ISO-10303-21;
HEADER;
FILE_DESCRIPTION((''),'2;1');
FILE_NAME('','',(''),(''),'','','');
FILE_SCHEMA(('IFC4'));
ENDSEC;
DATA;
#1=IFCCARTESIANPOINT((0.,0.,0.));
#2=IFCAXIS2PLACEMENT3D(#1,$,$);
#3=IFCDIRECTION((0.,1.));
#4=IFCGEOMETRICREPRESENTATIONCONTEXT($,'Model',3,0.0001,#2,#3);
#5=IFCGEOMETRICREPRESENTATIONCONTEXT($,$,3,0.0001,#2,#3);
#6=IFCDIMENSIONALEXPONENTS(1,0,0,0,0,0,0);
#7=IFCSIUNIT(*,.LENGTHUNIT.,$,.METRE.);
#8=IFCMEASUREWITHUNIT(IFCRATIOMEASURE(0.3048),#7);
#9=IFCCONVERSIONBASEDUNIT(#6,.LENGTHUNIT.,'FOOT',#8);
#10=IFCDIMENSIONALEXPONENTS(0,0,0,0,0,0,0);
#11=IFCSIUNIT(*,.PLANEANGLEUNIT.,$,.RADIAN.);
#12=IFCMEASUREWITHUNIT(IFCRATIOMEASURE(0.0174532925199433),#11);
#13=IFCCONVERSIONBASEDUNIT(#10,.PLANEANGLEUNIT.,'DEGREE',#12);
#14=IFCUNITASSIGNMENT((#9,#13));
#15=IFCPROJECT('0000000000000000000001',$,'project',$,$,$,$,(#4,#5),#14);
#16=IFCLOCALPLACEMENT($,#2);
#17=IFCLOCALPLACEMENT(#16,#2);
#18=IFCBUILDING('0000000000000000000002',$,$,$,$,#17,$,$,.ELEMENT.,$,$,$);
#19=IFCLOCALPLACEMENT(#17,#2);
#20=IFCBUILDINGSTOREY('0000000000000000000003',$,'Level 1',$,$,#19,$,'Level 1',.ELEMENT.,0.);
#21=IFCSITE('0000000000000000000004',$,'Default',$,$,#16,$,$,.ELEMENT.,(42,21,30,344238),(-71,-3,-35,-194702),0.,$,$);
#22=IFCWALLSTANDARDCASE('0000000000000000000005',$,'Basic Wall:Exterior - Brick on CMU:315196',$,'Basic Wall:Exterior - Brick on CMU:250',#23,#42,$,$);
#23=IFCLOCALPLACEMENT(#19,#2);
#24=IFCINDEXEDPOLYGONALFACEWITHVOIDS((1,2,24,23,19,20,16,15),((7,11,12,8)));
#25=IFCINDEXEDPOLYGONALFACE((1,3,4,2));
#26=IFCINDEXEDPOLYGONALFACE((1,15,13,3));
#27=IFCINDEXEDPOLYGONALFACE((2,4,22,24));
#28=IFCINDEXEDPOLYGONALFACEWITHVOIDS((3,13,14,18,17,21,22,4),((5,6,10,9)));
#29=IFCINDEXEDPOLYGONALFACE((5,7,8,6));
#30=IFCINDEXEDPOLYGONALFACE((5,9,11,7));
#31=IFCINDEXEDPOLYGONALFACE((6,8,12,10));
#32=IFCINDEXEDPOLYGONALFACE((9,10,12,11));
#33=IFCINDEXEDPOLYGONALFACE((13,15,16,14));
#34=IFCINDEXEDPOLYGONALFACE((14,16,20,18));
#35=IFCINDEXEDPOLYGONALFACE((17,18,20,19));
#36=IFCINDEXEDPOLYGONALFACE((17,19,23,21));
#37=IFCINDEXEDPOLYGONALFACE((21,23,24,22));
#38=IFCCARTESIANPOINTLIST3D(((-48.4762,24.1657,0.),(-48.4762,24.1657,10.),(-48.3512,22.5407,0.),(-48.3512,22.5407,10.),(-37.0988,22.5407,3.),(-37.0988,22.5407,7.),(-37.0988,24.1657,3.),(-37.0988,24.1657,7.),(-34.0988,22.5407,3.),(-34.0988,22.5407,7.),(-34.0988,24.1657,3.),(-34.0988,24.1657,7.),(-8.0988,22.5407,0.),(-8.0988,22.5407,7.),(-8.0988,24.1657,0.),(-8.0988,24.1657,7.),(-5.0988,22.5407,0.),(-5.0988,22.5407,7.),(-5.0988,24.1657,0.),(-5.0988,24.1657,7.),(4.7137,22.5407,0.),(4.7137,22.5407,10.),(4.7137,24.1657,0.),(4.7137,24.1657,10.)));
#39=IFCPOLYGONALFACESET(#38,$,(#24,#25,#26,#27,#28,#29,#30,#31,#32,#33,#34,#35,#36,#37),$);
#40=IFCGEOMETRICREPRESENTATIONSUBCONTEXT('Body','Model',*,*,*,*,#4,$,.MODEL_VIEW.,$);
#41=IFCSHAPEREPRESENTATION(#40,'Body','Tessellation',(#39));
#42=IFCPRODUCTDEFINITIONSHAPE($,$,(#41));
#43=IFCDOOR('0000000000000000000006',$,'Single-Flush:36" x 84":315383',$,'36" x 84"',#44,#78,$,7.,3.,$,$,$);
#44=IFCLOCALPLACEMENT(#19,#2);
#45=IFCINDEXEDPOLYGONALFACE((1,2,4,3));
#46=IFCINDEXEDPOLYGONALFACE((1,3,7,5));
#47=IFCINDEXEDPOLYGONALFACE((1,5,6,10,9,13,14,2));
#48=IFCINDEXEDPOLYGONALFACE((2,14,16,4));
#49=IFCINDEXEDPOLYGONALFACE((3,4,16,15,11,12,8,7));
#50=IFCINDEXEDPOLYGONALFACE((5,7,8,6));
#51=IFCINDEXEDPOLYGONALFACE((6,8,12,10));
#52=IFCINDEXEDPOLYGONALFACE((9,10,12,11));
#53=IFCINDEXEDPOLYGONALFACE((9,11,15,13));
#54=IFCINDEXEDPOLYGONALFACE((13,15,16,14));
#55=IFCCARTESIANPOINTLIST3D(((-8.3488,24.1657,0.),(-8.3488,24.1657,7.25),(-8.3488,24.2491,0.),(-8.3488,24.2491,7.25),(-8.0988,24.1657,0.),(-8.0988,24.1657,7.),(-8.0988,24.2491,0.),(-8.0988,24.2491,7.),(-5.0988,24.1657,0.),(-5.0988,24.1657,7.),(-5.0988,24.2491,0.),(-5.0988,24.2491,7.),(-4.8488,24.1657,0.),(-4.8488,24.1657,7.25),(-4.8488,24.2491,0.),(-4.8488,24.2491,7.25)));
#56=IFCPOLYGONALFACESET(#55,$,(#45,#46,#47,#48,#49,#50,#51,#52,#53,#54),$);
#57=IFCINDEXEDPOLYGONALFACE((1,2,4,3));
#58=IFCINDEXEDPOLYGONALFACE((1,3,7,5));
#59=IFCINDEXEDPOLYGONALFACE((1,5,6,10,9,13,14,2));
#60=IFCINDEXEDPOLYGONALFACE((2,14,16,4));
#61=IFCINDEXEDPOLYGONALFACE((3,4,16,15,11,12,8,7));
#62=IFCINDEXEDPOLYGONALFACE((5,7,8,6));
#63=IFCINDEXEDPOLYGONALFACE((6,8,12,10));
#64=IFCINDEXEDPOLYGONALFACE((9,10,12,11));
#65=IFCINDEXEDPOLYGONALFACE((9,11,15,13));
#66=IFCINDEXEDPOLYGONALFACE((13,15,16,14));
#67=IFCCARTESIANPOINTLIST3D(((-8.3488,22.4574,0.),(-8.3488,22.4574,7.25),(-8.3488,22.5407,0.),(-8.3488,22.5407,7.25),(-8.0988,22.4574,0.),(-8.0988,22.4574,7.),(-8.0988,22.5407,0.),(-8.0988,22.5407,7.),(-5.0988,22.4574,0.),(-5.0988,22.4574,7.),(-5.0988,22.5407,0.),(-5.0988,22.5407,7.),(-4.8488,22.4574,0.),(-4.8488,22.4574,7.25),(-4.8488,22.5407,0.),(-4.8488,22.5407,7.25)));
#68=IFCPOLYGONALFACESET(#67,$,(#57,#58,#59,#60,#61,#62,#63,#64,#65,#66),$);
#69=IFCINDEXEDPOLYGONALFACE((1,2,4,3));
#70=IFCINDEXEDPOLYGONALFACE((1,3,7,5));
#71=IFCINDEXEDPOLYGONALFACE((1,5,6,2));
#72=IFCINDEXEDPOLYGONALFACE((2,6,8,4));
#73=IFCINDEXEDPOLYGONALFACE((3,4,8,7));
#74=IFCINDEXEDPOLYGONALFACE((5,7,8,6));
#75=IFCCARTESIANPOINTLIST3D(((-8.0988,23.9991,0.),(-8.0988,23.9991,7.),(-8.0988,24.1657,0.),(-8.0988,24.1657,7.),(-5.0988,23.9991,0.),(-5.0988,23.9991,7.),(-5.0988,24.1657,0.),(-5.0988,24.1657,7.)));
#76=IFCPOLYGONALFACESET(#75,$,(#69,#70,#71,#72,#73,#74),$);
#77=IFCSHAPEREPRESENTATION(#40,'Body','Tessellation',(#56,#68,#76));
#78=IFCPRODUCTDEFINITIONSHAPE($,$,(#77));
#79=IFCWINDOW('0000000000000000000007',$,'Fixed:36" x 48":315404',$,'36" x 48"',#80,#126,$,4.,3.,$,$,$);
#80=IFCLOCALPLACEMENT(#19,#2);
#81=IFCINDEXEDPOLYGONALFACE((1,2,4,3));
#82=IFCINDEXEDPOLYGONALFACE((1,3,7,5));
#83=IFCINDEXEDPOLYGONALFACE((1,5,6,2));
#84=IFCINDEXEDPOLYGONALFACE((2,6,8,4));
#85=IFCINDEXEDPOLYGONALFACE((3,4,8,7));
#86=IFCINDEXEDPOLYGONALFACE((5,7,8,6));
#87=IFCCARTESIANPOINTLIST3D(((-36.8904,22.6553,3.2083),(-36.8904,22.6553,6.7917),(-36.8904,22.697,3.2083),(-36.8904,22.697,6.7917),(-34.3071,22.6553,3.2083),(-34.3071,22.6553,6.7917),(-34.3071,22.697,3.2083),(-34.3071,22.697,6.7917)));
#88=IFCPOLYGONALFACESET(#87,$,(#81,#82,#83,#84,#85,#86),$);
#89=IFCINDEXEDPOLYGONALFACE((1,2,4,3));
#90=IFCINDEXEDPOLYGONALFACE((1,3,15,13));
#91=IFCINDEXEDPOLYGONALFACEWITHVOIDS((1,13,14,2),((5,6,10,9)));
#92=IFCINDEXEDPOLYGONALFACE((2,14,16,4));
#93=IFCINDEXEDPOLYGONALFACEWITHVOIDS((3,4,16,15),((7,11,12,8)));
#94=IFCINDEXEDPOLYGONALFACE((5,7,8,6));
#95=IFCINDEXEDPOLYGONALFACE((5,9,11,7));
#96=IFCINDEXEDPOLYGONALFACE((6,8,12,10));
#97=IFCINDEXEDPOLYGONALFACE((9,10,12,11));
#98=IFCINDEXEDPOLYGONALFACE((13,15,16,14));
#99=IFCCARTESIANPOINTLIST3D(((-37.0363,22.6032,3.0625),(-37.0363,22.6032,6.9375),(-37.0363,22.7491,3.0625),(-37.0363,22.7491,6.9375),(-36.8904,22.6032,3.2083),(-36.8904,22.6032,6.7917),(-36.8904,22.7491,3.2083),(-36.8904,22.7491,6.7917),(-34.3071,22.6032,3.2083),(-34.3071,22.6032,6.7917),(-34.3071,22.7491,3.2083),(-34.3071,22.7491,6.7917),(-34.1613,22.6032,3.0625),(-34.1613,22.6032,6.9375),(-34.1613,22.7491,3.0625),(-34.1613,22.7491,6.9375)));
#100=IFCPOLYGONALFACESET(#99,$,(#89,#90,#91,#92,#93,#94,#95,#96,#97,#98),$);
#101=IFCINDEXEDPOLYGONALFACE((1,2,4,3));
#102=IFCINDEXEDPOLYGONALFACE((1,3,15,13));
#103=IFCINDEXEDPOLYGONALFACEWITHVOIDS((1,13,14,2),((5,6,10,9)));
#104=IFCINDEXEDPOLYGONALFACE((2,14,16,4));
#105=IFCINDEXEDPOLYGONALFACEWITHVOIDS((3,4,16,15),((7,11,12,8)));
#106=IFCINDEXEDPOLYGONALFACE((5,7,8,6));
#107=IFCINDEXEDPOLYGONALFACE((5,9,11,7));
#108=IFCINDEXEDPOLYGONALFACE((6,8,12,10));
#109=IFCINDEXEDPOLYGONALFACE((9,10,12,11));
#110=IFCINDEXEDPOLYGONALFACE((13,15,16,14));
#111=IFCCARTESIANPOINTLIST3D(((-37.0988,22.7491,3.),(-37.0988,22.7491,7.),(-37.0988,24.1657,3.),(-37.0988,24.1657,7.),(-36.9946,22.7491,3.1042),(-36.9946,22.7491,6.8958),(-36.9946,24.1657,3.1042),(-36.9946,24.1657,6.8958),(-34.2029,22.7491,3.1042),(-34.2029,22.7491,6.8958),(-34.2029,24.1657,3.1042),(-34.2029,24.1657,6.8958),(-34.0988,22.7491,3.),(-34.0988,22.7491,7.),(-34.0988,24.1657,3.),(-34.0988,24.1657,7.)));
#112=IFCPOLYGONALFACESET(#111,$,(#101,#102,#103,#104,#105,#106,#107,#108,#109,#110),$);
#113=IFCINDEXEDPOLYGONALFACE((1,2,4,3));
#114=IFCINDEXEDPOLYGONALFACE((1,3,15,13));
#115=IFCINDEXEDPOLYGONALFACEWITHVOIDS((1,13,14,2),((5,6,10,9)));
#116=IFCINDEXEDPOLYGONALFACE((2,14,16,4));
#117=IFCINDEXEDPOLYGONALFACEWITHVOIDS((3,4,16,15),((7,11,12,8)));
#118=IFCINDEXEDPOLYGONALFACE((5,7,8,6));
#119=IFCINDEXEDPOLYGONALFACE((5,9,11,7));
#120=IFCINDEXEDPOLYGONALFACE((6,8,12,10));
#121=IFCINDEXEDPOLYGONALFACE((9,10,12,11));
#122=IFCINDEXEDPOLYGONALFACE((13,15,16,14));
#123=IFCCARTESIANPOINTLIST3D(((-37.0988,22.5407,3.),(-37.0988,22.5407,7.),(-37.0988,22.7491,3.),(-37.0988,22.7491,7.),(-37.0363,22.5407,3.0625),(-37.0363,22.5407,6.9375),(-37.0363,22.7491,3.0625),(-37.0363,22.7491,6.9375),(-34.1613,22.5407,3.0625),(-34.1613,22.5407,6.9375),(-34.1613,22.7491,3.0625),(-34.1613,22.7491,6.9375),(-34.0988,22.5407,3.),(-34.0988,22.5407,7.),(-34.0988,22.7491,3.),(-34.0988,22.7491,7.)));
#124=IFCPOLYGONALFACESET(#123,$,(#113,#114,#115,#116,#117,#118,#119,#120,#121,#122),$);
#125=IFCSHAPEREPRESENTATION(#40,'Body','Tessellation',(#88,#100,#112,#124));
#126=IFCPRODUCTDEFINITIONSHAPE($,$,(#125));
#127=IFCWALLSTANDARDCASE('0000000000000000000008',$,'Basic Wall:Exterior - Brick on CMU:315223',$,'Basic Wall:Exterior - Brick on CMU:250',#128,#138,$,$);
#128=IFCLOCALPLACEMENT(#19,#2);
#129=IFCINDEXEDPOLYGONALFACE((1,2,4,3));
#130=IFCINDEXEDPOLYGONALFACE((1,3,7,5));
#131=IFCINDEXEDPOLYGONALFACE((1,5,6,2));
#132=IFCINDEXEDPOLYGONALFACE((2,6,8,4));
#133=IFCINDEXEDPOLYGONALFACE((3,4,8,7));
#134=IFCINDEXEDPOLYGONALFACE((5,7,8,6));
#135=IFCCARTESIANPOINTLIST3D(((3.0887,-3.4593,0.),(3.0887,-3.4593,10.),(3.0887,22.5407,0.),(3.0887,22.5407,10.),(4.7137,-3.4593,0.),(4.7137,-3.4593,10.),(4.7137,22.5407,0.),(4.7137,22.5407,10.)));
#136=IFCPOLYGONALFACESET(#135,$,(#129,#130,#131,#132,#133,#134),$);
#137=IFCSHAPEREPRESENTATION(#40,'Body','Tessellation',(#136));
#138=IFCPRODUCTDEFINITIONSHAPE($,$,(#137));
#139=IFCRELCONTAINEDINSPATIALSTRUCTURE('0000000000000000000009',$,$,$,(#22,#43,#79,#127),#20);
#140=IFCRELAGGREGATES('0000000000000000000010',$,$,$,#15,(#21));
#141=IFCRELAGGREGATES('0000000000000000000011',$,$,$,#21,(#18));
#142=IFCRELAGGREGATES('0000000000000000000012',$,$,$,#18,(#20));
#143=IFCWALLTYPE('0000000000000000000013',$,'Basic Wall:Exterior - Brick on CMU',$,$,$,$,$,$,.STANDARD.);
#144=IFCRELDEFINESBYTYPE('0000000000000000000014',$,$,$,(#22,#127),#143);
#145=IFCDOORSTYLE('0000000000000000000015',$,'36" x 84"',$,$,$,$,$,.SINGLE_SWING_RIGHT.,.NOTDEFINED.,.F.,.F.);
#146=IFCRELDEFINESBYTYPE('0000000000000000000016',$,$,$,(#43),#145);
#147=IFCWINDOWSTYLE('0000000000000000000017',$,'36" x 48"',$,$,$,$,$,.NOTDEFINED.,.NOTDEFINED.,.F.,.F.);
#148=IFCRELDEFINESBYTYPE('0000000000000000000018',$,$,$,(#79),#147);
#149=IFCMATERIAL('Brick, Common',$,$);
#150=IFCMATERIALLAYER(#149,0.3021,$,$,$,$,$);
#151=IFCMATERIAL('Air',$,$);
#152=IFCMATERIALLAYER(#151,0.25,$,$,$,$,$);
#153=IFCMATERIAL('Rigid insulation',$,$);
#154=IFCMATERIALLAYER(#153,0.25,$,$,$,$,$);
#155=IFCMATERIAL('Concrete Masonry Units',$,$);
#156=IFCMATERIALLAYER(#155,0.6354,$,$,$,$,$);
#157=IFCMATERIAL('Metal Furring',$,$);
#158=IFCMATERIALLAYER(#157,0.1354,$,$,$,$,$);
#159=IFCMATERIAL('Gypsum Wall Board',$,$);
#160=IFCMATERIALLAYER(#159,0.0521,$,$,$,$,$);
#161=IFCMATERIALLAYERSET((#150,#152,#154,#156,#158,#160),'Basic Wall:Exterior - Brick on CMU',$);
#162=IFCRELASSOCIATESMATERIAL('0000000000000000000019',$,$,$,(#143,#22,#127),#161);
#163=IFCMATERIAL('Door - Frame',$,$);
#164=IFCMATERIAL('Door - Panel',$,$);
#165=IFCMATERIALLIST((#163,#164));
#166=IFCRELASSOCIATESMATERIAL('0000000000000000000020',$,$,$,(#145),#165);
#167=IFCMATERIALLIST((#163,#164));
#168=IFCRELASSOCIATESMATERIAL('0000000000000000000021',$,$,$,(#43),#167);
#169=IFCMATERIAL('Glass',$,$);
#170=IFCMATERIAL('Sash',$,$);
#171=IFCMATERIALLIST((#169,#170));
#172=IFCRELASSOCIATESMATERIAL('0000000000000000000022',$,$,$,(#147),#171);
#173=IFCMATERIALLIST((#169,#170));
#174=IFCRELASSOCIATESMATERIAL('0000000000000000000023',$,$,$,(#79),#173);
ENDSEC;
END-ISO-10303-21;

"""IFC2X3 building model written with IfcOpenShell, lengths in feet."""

from ifc_helpers import new_model, entity, si_unit, converted_unit, direction, frame, frame_2d, origin, place, context, subcontext, project, spatial, polyline, rectangle, outline, extrude, clip, bounded_halfspace, source, transform, mapped, material, material_list, layer, layer_set, layer_usage, type_object, type_shapes, element, fill, save


model = new_model("IFC2X3")

# Units and contexts
model_context = context("Model", 3, precision=0.0001, world=origin(), true_north=direction((0.0, 1.0)))
context_of_model = context(None, 3, precision=0.0001, world=origin(), true_north=direction((0.0, 1.0)))
body_context = subcontext(model_context, "Body", "Model", "MODEL_VIEW")
ifc_project = project(units=[converted_unit("LENGTHUNIT", "FOOT", entity("IfcRatioMeasure", 0.3048), si_unit("LENGTHUNIT", "METRE"), dimensions=[1, 0, 0, 0, 0, 0, 0]), converted_unit("PLANEANGLEUNIT", "DEGREE", entity("IfcRatioMeasure", 0.0174532925199433), si_unit("PLANEANGLEUNIT", "RADIAN"), dimensions=[0, 0, 0, 0, 0, 0, 0])], contexts=[model_context, context_of_model])

# Site, building, storey
site_placement = place(None, origin())
site = spatial("IfcSite", under=ifc_project, at=site_placement, Name="Default", CompositionType="ELEMENT", RefLatitude=(42, 21, 30, 344238), RefLongitude=(-71, -3, -35, -194702), RefElevation=0.0)
building_placement = place(site_placement, origin())
building = spatial("IfcBuilding", under=site, at=building_placement, CompositionType="ELEMENT")
storey_placement = place(building_placement, origin())
storey = spatial("IfcBuildingStorey", under=building, at=storey_placement, Name="Level 1", LongName="Level 1", CompositionType="ELEMENT", Elevation=0.0)

# Wall, openings, door, window
ifc_material_1 = material(Name="Brick, Common")
ifc_layer_1 = layer(ifc_material_1, 0.3021)
ifc_material_2 = material(Name="Air")
ifc_layer_2 = layer(ifc_material_2, 0.25)
ifc_material_3 = material(Name="Rigid insulation")
ifc_layer_3 = layer(ifc_material_3, 0.25)
ifc_material_4 = material(Name="Concrete Masonry Units")
ifc_layer_4 = layer(ifc_material_4, 0.6354)
ifc_material_5 = material(Name="Metal Furring")
ifc_layer_5 = layer(ifc_material_5, 0.1354)
ifc_material_6 = material(Name="Gypsum Wall Board")
ifc_layer_6 = layer(ifc_material_6, 0.0521)
ifc_layer_set_1 = layer_set([ifc_layer_1, ifc_layer_2, ifc_layer_3, ifc_layer_4, ifc_layer_5, ifc_layer_6], Name="Basic Wall:Exterior - Brick on CMU")
ifc_layer_usage_1 = layer_usage(ifc_layer_set_1, "AXIS2", "NEGATIVE", 0.8125)
wall_type_1 = type_object("IfcWallType", Name="Basic Wall:Exterior - Brick on CMU", PredefinedType="STANDARD", material=ifc_layer_set_1)
wall_1_placement = place(storey_placement, frame((-48.4762, 23.3532, 0.0)))
wall_1 = element("IfcWallStandardCase", 1, at=wall_1_placement, inside=storey, type_object=wall_type_1, material=ifc_layer_usage_1, Name="Basic Wall:Exterior - Brick on CMU:315196", ObjectType="Basic Wall:Exterior - Brick on CMU:250", context=body_context, shape_type="Clipping", body=[
    clip(extrude(outline(polyline([(0.125, -0.8125), (1.7548, -0.8125), (26.3556, -0.8125), (27.0242, -0.8125), (51.5649, -0.8125), (53.1899, -0.8125), (53.1899, 0.8125), (0.0, 0.8125), (0.125, -0.8125)])), origin(), (0.0, 0.0, 1.0), 10.0), bounded_halfspace(frame((0.125, -0.8125, 10.0)), False, frame((0.125, -0.8125, 10.0)), polyline([(0.0, 0.0), (1.6298, 0.0), (26.2306, 0.0), (26.8992, 0.0), (51.4399, 0.0), (53.0649, 0.0), (53.0649, 1.625), (-0.125, 1.625), (0.0, 0.0)]))),
])
opening_1_placement = place(wall_1_placement, frame((40.3774, -0.8125, 0.0)))
opening_1 = element("IfcOpeningElement", 2, at=opening_1_placement, cuts=wall_1, ObjectType="Opening", context=body_context, shape_type="SweptSolid", body=[
    extrude(rectangle(XDim=3.0, YDim=7.0, at=frame_2d((3.5, 1.5), x_axis=(0.0, 1.0))), frame((0.0, 0.0, 0.0), z_axis=(0.0, 1.0, 0.0), x_axis=(0.0, 0.0, 1.0)), (0.0, 0.0, 1.0), 1.625),
])
opening_2_placement = place(wall_1_placement, frame((14.3774, 0.8125, 3.0)))
opening_2 = element("IfcOpeningElement", 3, at=opening_2_placement, cuts=wall_1, ObjectType="Opening", context=body_context, shape_type="SweptSolid", body=[
    extrude(rectangle(XDim=4.0, YDim=3.0, at=frame_2d((2.0, 1.5), x_axis=(-1.0, 0.0))), frame((0.0, 0.0, 0.0), z_axis=(0.0, -1.0, 0.0), x_axis=(0.0, 0.0, 1.0)), (0.0, 0.0, 1.0), 1.625),
])
ifc_material_7 = material(Name="Door - Frame")
ifc_material_8 = material(Name="Door - Panel")
ifc_material_list_1 = material_list([ifc_material_7, ifc_material_8])
ifc_material_list_2 = material_list([ifc_material_7, ifc_material_8])
door_style_1 = type_object("IfcDoorStyle", Name="36\" x 84\"", ConstructionType="NOTDEFINED", OperationType="SINGLE_SWING_RIGHT", ParameterTakesPrecedence=False, Sizeable=False, material=ifc_material_list_2)
shared_shape_1 = source(origin(), body_context, "Body", "SweptSolid", [
    extrude(outline(polyline([(-1.75, -3.6875), (1.75, -3.6875), (1.75, 3.5625), (1.5, 3.5625), (1.5, -3.4375), (-1.5, -3.4375), (-1.5, 3.5625), (-1.75, 3.5625), (-1.75, -3.6875)])), frame((1.5, 1.625, 3.5625), z_axis=(0.0, 1.0, 0.0), x_axis=(1.0, 0.0, 0.0)), (0.0, 0.0, 1.0), 0.0833),
    extrude(outline(polyline([(-3.6875, -1.75), (3.5625, -1.75), (3.5625, -1.5), (-3.4375, -1.5), (-3.4375, 1.5), (3.5625, 1.5), (3.5625, 1.75), (-3.6875, 1.75), (-3.6875, -1.75)])), frame((1.5, -0.0833, 3.5625), z_axis=(0.0, 1.0, 0.0), x_axis=(0.0, 0.0, -1.0)), (0.0, 0.0, 1.0), 0.0833),
    extrude(rectangle(XDim=0.1667, YDim=3.0, at=frame_2d((0.0, 0.0), x_axis=(1.0, 0.0))), frame((1.5, 1.5417, 0.0), z_axis=(0.0, 0.0, 1.0), x_axis=(0.0, 1.0, 0.0)), (0.0, 0.0, 1.0), 7.0),
])
type_shapes(door_style_1, [shared_shape_1])
door_1_placement = place(opening_1_placement, origin())
door_1 = element("IfcDoor", 4, at=door_1_placement, inside=storey, type_object=door_style_1, material=ifc_material_list_1, Name="Single-Flush:36\" x 84\":315383", ObjectType="36\" x 84\"", OverallHeight=7.0, OverallWidth=3.0, context=body_context, shape_type="MappedRepresentation", body=[
    mapped(shared_shape_1, transform((0.0, 0.0, 0.0), scale=1.0)),
])
fill(opening_1, door_1)
ifc_material_9 = material(Name="Glass")
ifc_material_10 = material(Name="Sash")
ifc_material_list_3 = material_list([ifc_material_9, ifc_material_10])
ifc_material_list_4 = material_list([ifc_material_9, ifc_material_10])
window_style_1 = type_object("IfcWindowStyle", Name="36\" x 48\"", ConstructionType="NOTDEFINED", OperationType="NOTDEFINED", ParameterTakesPrecedence=False, Sizeable=False, material=ifc_material_list_4)
shared_shape_2 = source(origin(), body_context, "Body", "SweptSolid", [
    extrude(rectangle(XDim=0.0417, YDim=2.5833, at=frame_2d((0.0, 0.0), x_axis=(1.0, 0.0))), frame((1.5, 1.4896, 0.2083), z_axis=(0.0, 0.0, 1.0), x_axis=(0.0, 1.0, 0.0)), (0.0, 0.0, 1.0), 3.5833),
    extrude(outline(polyline([(-1.4375, -1.9375), (1.4375, -1.9375), (1.4375, 1.9375), (-1.4375, 1.9375), (-1.4375, -1.9375)]), holes=[polyline([(-1.2917, -1.7917), (-1.2917, 1.7917), (1.2917, 1.7917), (1.2917, -1.7917), (-1.2917, -1.7917)])]), frame((1.5, 1.4167, 2.0), z_axis=(0.0, 1.0, 0.0), x_axis=(1.0, 0.0, 0.0)), (0.0, 0.0, 1.0), 0.1458),
    extrude(outline(polyline([(-1.5, -2.0), (1.5, -2.0), (1.5, 2.0), (-1.5, 2.0), (-1.5, -2.0)]), holes=[polyline([(-1.3958, -1.8958), (-1.3958, 1.8958), (1.3958, 1.8958), (1.3958, -1.8958), (-1.3958, -1.8958)])]), frame((1.5, 0.0, 2.0), z_axis=(0.0, 1.0, 0.0), x_axis=(1.0, 0.0, 0.0)), (0.0, 0.0, 1.0), 1.4167),
    extrude(outline(polyline([(-2.0, -1.5), (2.0, -1.5), (2.0, 1.5), (-2.0, 1.5), (-2.0, -1.5)]), holes=[polyline([(-1.9375, -1.4375), (-1.9375, 1.4375), (1.9375, 1.4375), (1.9375, -1.4375), (-1.9375, -1.4375)])]), frame((1.5, 1.4167, 2.0), z_axis=(0.0, 1.0, 0.0), x_axis=(0.0, 0.0, -1.0)), (0.0, 0.0, 1.0), 0.2083),
])
type_shapes(window_style_1, [shared_shape_2])
window_1_placement = place(opening_2_placement, frame((0.0, 0.0, 0.0), z_axis=(0.0, 0.0, 1.0), x_axis=(-1.0, 0.0, 0.0)))
window_1 = element("IfcWindow", 5, at=window_1_placement, inside=storey, type_object=window_style_1, material=ifc_material_list_3, Name="Fixed:36\" x 48\":315404", ObjectType="36\" x 48\"", OverallHeight=4.0, OverallWidth=3.0, context=body_context, shape_type="MappedRepresentation", body=[
    mapped(shared_shape_2, transform((0.0, 0.0, 0.0), scale=1.0)),
])
fill(opening_2, window_1)

# Wall
ifc_layer_usage_2 = layer_usage(ifc_layer_set_1, "AXIS2", "NEGATIVE", 0.8125)
wall_2_placement = place(storey_placement, frame((3.9012, 22.5407, 0.0), z_axis=(0.0, 0.0, 1.0), x_axis=(0.0, -1.0, 0.0)))
element("IfcWallStandardCase", 6, at=wall_2_placement, inside=storey, type_object=wall_type_1, material=ifc_layer_usage_2, Name="Basic Wall:Exterior - Brick on CMU:315223", ObjectType="Basic Wall:Exterior - Brick on CMU:250", context=body_context, shape_type="Clipping", body=[
    clip(extrude(rectangle(XDim=26.0, YDim=1.625, at=frame_2d((13.0, 0.0), x_axis=(-1.0, 0.0))), origin(), (0.0, 0.0, 1.0), 10.0), bounded_halfspace(frame((0.0, -0.8125, 10.0), z_axis=(0.0, 0.0, 1.0), x_axis=(0.0, 1.0, 0.0)), False, frame((0.0, -0.8125, 10.0)), polyline([(0.0, 0.0), (24.375, 0.0), (26.0, 0.0), (26.0, 1.625), (0.0, 1.625), (0.0, 0.0)]))),
])

save(model, "model.ifc")
